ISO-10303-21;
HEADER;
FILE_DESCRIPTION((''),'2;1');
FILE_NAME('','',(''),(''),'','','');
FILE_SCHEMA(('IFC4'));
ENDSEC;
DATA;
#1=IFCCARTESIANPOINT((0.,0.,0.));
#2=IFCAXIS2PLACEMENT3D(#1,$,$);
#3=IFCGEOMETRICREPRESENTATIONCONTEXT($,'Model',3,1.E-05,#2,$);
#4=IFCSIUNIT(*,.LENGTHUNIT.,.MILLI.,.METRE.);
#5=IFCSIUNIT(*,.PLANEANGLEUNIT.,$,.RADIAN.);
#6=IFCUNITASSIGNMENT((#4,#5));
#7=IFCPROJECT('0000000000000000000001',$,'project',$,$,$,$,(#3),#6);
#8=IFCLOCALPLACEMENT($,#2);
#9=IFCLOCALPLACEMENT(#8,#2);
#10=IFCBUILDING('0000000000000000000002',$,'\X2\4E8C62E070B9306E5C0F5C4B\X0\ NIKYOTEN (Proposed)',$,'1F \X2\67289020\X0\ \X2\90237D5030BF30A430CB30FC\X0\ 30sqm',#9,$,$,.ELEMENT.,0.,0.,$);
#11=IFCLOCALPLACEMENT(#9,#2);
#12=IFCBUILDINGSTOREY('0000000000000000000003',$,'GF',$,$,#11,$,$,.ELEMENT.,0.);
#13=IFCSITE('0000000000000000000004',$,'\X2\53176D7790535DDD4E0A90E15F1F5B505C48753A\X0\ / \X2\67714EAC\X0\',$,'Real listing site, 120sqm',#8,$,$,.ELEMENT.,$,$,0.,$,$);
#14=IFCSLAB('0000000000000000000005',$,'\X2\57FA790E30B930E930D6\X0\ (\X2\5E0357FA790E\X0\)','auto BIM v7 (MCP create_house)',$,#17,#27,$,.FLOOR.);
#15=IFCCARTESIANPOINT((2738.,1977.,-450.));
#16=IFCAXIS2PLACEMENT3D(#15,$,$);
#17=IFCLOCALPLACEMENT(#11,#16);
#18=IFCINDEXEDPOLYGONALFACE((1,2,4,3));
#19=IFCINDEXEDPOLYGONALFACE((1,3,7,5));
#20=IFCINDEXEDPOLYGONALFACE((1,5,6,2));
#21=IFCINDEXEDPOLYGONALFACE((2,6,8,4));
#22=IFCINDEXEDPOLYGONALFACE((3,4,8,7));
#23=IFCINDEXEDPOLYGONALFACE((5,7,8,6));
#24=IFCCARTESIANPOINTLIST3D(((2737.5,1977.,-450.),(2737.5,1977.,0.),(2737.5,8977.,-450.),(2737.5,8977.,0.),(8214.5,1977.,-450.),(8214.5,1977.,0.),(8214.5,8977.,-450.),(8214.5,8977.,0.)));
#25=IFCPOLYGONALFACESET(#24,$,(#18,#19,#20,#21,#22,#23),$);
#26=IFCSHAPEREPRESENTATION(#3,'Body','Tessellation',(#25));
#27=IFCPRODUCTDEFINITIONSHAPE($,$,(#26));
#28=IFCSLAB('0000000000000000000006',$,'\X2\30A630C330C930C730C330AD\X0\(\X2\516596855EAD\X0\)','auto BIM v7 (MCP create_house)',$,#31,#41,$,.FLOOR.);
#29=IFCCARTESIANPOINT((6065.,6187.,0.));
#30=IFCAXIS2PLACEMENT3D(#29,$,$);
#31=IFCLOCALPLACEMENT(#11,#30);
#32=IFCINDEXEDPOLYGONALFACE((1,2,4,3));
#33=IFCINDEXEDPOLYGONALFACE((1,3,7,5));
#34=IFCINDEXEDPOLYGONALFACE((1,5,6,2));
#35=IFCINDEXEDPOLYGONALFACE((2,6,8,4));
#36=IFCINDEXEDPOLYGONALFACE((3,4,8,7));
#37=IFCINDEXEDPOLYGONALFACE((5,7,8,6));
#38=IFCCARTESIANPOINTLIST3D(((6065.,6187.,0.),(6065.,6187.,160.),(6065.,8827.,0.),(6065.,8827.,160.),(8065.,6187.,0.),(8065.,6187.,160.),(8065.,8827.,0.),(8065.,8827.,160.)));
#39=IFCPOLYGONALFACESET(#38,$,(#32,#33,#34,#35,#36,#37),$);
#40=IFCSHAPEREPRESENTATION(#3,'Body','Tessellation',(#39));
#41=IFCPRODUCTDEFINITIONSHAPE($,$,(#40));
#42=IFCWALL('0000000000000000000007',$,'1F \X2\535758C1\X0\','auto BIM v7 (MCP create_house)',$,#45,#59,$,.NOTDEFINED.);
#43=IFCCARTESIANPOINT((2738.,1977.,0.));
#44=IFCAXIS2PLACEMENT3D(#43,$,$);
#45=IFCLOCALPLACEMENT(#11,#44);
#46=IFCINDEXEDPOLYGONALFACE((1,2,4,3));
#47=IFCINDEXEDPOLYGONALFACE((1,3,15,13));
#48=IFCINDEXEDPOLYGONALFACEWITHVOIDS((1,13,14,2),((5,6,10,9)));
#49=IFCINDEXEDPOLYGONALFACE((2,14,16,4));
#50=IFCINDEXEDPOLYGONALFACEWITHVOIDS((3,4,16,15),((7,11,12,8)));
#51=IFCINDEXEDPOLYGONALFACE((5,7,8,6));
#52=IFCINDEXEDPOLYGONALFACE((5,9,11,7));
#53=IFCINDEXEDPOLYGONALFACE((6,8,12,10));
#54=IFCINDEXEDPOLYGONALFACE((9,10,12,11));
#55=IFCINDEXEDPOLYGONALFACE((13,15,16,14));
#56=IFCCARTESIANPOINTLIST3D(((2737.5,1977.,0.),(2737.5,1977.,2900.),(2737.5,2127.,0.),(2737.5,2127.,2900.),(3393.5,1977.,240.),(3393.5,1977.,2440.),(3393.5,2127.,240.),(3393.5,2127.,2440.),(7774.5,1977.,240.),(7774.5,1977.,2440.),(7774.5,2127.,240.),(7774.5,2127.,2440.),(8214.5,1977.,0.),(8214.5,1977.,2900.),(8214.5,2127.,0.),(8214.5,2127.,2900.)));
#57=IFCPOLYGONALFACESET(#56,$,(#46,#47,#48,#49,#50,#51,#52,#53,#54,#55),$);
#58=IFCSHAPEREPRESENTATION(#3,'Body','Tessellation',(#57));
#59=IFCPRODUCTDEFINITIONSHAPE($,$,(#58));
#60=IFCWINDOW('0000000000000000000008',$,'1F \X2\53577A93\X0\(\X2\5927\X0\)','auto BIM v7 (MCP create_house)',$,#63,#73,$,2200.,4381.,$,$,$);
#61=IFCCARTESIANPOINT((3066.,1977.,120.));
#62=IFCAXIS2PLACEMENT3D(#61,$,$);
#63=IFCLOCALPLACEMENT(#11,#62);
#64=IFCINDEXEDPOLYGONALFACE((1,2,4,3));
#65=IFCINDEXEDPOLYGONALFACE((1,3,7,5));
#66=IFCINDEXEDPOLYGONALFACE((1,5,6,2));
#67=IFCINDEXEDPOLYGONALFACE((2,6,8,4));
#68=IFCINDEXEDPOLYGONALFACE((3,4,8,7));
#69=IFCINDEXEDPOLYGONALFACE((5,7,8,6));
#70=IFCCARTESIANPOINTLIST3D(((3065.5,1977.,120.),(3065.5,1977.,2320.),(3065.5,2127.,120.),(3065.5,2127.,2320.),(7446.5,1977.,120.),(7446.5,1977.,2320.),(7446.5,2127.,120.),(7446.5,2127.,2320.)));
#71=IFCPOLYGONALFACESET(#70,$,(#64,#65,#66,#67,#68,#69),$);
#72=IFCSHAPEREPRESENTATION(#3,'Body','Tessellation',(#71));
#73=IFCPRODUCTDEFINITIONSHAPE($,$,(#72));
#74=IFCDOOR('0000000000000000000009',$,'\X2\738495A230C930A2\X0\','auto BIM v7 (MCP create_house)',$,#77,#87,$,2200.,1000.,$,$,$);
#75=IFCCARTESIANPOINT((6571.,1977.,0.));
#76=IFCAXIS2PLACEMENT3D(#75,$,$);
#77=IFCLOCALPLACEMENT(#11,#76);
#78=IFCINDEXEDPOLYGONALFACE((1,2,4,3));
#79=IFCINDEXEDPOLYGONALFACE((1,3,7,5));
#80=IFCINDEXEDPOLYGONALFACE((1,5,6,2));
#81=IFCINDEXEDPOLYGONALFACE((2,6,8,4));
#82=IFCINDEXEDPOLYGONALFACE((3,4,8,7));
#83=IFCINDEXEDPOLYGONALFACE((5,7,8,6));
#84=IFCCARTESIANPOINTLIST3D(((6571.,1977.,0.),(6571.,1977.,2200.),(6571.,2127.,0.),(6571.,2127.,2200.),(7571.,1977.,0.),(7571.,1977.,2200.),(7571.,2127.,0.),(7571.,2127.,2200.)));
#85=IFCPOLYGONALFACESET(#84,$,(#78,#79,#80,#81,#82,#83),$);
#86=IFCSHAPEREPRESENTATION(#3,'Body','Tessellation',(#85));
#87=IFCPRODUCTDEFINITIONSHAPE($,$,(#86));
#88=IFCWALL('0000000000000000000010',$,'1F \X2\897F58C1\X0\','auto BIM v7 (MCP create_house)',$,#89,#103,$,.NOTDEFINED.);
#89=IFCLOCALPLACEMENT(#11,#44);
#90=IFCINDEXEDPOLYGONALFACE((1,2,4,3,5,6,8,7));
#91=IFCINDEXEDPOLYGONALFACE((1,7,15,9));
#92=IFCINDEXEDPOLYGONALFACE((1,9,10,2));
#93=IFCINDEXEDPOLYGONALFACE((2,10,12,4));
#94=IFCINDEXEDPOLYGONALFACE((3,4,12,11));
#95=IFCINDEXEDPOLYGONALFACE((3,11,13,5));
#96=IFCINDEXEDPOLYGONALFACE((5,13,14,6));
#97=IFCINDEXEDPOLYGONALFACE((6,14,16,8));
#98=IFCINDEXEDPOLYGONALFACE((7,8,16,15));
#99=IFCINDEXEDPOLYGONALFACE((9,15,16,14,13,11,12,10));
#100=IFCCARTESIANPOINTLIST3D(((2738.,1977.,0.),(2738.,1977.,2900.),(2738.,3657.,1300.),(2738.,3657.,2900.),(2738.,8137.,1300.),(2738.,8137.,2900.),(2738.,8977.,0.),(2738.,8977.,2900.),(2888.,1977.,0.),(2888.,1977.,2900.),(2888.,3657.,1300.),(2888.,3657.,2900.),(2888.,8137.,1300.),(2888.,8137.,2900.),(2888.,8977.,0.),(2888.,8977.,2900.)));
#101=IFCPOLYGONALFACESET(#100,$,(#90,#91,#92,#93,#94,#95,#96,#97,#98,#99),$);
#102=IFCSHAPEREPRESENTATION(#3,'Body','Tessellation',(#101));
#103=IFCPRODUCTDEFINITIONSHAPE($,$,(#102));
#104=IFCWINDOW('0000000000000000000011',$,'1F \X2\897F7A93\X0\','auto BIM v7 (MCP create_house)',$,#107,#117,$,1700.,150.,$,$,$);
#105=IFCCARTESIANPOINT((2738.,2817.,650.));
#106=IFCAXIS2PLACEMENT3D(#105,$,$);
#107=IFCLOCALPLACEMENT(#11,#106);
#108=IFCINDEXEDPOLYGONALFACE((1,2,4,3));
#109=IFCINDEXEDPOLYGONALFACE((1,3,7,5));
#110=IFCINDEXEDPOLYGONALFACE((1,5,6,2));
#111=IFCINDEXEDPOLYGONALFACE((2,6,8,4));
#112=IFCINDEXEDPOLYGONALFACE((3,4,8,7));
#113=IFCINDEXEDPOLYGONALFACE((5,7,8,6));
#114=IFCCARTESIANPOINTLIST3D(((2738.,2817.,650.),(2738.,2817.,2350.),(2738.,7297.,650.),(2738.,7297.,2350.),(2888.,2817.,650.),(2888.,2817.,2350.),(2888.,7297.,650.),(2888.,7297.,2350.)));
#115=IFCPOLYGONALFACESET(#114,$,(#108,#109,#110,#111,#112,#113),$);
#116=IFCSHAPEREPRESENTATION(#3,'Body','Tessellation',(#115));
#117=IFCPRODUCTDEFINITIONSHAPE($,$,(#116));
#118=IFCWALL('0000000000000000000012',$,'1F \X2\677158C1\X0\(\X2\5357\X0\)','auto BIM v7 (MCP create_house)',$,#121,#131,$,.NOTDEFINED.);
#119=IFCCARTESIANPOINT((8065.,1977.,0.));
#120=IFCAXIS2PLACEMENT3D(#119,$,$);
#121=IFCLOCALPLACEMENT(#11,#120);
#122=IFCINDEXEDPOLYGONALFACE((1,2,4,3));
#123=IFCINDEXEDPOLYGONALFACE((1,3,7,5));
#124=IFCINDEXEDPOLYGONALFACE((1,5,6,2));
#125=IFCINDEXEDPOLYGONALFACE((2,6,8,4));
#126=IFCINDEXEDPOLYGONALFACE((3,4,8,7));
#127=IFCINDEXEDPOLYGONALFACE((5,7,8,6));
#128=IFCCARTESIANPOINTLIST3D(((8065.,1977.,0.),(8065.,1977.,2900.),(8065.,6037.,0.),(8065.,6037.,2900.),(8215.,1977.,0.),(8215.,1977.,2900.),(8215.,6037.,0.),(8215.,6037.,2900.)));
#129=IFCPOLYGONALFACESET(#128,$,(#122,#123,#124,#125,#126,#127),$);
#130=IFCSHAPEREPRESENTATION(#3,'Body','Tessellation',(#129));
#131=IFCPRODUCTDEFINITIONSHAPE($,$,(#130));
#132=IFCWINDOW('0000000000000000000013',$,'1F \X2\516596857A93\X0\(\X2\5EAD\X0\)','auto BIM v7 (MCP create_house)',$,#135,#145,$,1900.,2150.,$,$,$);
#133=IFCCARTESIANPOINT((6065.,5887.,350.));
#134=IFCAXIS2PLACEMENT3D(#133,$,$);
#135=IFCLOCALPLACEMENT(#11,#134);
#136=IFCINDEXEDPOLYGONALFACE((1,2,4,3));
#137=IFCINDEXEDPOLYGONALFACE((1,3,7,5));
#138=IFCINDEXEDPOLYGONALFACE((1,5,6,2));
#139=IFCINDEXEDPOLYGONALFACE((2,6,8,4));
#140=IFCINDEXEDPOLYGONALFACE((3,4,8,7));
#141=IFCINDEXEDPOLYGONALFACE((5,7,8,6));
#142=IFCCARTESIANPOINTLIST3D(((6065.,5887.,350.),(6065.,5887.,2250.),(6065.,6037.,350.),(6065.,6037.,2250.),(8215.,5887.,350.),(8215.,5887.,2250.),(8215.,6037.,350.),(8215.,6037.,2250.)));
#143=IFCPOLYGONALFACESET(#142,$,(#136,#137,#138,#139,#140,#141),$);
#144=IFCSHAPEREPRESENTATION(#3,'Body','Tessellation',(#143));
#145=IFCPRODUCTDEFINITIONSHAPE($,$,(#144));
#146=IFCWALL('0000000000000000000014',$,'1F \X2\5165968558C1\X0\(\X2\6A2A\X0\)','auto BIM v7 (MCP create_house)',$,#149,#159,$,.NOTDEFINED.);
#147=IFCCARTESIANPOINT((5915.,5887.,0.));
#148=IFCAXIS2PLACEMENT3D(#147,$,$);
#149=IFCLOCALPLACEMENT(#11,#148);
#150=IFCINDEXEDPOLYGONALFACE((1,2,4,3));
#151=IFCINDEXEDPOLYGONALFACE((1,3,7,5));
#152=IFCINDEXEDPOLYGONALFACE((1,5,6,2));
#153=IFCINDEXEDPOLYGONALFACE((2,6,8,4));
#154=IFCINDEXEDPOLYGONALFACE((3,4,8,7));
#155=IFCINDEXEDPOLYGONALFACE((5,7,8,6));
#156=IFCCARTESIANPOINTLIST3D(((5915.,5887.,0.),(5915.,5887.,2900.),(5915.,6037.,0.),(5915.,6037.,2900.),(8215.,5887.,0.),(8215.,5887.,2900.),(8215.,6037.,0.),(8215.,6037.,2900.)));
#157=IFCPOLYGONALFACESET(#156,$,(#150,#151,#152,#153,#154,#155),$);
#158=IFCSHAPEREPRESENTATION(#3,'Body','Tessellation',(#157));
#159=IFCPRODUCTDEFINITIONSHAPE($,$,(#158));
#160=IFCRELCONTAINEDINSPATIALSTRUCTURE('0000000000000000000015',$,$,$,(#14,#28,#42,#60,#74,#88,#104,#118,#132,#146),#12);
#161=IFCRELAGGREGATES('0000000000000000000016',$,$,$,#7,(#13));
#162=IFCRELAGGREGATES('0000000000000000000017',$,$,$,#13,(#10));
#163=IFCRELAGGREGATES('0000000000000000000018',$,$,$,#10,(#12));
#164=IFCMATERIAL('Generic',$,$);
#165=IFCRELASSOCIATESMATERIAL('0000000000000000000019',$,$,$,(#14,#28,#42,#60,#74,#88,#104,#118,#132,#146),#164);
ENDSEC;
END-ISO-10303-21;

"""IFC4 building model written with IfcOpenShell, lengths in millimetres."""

from ifc_helpers import new_model, si_unit, frame, frame_2d, origin, place, context, project, spatial, rectangle, extrude, material, element, fill, save


model = new_model("IFC4")

# Units and contexts
model_context = context("Model", 3, precision=1e-05, world=origin())
ifc_project = project(units=[si_unit("LENGTHUNIT", "METRE", prefix="MILLI"), si_unit("PLANEANGLEUNIT", "RADIAN")], contexts=[model_context])

# Site, building, storey
site_placement = place(None, origin())
site = spatial("IfcSite", under=ifc_project, at=site_placement, Name="北海道川上郡弟子屈町 / 東京", ObjectType="Real listing site, 120sqm", CompositionType="ELEMENT", RefElevation=0.0)
building_placement = place(site_placement, origin())
building = spatial("IfcBuilding", under=site, at=building_placement, Name="二拠点の小屋 NIKYOTEN (Proposed)", ObjectType="1F 木造 連結タイニー 30sqm", CompositionType="ELEMENT", ElevationOfRefHeight=0.0, ElevationOfTerrain=0.0)
storey_placement = place(building_placement, origin())
storey = spatial("IfcBuildingStorey", under=building, at=storey_placement, Name="GF", CompositionType="ELEMENT", Elevation=0.0)

# Slabs
ifc_material = material(Name="Generic")
slab_1_placement = place(storey_placement, frame((2738.0, 1977.0, -450.0)))
element("IfcSlab", 1, at=slab_1_placement, inside=storey, material=ifc_material, Name="基礎スラブ (布基礎)", Description="auto BIM v7 (MCP create_house)", PredefinedType="FLOOR", context=model_context, shape_type="SweptSolid", body=[
    extrude(rectangle(XDim=5477.0, YDim=7000.0, at=frame_2d((2738.0, 3500.0))), frame((2738.0, 1977.0, -450.0)), (0.0, 0.0, 1.0), 450.0),
])
slab_2_placement = place(storey_placement, frame((6065.0, 6187.0, 0.0)))
element("IfcSlab", 2, at=slab_2_placement, inside=storey, material=ifc_material, Name="ウッドデッキ(入隅庭)", Description="auto BIM v7 (MCP create_house)", PredefinedType="FLOOR", context=model_context, shape_type="SweptSolid", body=[
    extrude(rectangle(XDim=2000.0, YDim=2640.0, at=frame_2d((1000.0, 1320.0))), frame((6065.0, 6187.0, 0.0)), (0.0, 0.0, 1.0), 160.0),
])

# Wall, openings, window, door
wall_1_placement = place(storey_placement, frame((2738.0, 1977.0, 0.0)))
wall_1 = element("IfcWall", 3, at=wall_1_placement, inside=storey, material=ifc_material, Name="1F 南壁", Description="auto BIM v7 (MCP create_house)", PredefinedType="NOTDEFINED", context=model_context, shape_type="SweptSolid", body=[
    extrude(rectangle(XDim=5477.0, YDim=150.0, at=frame_2d((2738.0, 75.0))), frame((2738.0, 1977.0, 0.0)), (0.0, 0.0, 1.0), 2900.0),
])
opening_1_placement = place(storey_placement, frame((3066.0, 1977.0, 120.0)))
opening_1 = element("IfcOpeningElement", 4, at=opening_1_placement, cuts=wall_1, PredefinedType="NOTDEFINED", context=model_context, shape_type="SweptSolid", body=[
    extrude(rectangle(XDim=4381.0, YDim=150.0, at=frame_2d((2190.0, 75.0))), frame((3066.0, 1977.0, 120.0)), (0.0, 0.0, 1.0), 2200.0),
])
opening_2_placement = place(storey_placement, frame((6571.0, 1977.0, 0.0)))
opening_2 = element("IfcOpeningElement", 5, at=opening_2_placement, cuts=wall_1, PredefinedType="NOTDEFINED", context=model_context, shape_type="SweptSolid", body=[
    extrude(rectangle(XDim=1000.0, YDim=150.0, at=frame_2d((500.0, 75.0))), frame((6571.0, 1977.0, 0.0)), (0.0, 0.0, 1.0), 2200.0),
])
window_1_placement = place(storey_placement, frame((3066.0, 1977.0, 120.0)))
window_1 = element("IfcWindow", 6, at=window_1_placement, inside=storey, material=ifc_material, Name="1F 南窓(大)", Description="auto BIM v7 (MCP create_house)", OverallHeight=2200.0, OverallWidth=4381.0, context=model_context, shape_type="SweptSolid", body=[
    extrude(rectangle(XDim=4381.0, YDim=150.0, at=frame_2d((2190.0, 75.0))), frame((3066.0, 1977.0, 120.0)), (0.0, 0.0, 1.0), 2200.0),
])
fill(opening_1, window_1)
door_placement = place(storey_placement, frame((6571.0, 1977.0, 0.0)))
door = element("IfcDoor", 7, at=door_placement, inside=storey, material=ifc_material, Name="玄関ドア", Description="auto BIM v7 (MCP create_house)", OverallHeight=2200.0, OverallWidth=1000.0, context=model_context, shape_type="SweptSolid", body=[
    extrude(rectangle(XDim=1000.0, YDim=150.0, at=frame_2d((500.0, 75.0))), frame((6571.0, 1977.0, 0.0)), (0.0, 0.0, 1.0), 2200.0),
])
fill(opening_2, door)

# Wall, opening, window
wall_2_placement = place(storey_placement, frame((2738.0, 1977.0, 0.0)))
wall_2 = element("IfcWall", 8, at=wall_2_placement, inside=storey, material=ifc_material, Name="1F 西壁", Description="auto BIM v7 (MCP create_house)", PredefinedType="NOTDEFINED", context=model_context, shape_type="SweptSolid", body=[
    extrude(rectangle(XDim=150.0, YDim=7000.0, at=frame_2d((75.0, 3500.0))), frame((2738.0, 1977.0, 0.0)), (0.0, 0.0, 1.0), 2900.0),
])
opening_3_placement = place(storey_placement, frame((2738.0, 2817.0, 650.0)))
opening_3 = element("IfcOpeningElement", 9, at=opening_3_placement, cuts=wall_2, PredefinedType="NOTDEFINED", context=model_context, shape_type="SweptSolid", body=[
    extrude(rectangle(XDim=150.0, YDim=4480.0, at=frame_2d((75.0, 2240.0))), frame((2738.0, 2817.0, 650.0)), (0.0, 0.0, 1.0), 1700.0),
])
window_2_placement = place(storey_placement, frame((2738.0, 2817.0, 650.0)))
window_2 = element("IfcWindow", 10, at=window_2_placement, inside=storey, material=ifc_material, Name="1F 西窓", Description="auto BIM v7 (MCP create_house)", OverallHeight=1700.0, OverallWidth=150.0, context=model_context, shape_type="SweptSolid", body=[
    extrude(rectangle(XDim=150.0, YDim=4480.0, at=frame_2d((75.0, 2240.0))), frame((2738.0, 2817.0, 650.0)), (0.0, 0.0, 1.0), 1700.0),
])
fill(opening_3, window_2)

# Wall, opening, window
wall_3_placement = place(storey_placement, frame((8065.0, 1977.0, 0.0)))
wall_3 = element("IfcWall", 11, at=wall_3_placement, inside=storey, material=ifc_material, Name="1F 東壁(南)", Description="auto BIM v7 (MCP create_house)", PredefinedType="NOTDEFINED", context=model_context, shape_type="SweptSolid", body=[
    extrude(rectangle(XDim=150.0, YDim=4060.0, at=frame_2d((75.0, 2030.0))), frame((8065.0, 1977.0, 0.0)), (0.0, 0.0, 1.0), 2900.0),
])
opening_4_placement = place(storey_placement, frame((6065.0, 5887.0, 350.0)))
opening_4 = element("IfcOpeningElement", 12, at=opening_4_placement, cuts=wall_3, PredefinedType="NOTDEFINED", context=model_context, shape_type="SweptSolid", body=[
    extrude(rectangle(XDim=2150.0, YDim=150.0, at=frame_2d((1075.0, 75.0))), frame((6065.0, 5887.0, 350.0)), (0.0, 0.0, 1.0), 1900.0),
])
window_3_placement = place(storey_placement, frame((6065.0, 5887.0, 350.0)))
window_3 = element("IfcWindow", 13, at=window_3_placement, inside=storey, material=ifc_material, Name="1F 入隅窓(庭)", Description="auto BIM v7 (MCP create_house)", OverallHeight=1900.0, OverallWidth=2150.0, context=model_context, shape_type="SweptSolid", body=[
    extrude(rectangle(XDim=2150.0, YDim=150.0, at=frame_2d((1075.0, 75.0))), frame((6065.0, 5887.0, 350.0)), (0.0, 0.0, 1.0), 1900.0),
])
fill(opening_4, window_3)

# Wall
wall_4_placement = place(storey_placement, frame((5915.0, 5887.0, 0.0)))
element("IfcWall", 14, at=wall_4_placement, inside=storey, material=ifc_material, Name="1F 入隅壁(横)", Description="auto BIM v7 (MCP create_house)", PredefinedType="NOTDEFINED", context=model_context, shape_type="SweptSolid", body=[
    extrude(rectangle(XDim=2300.0, YDim=150.0, at=frame_2d((1150.0, 75.0))), frame((5915.0, 5887.0, 0.0)), (0.0, 0.0, 1.0), 2900.0),
])

save(model, "model.ifc")
